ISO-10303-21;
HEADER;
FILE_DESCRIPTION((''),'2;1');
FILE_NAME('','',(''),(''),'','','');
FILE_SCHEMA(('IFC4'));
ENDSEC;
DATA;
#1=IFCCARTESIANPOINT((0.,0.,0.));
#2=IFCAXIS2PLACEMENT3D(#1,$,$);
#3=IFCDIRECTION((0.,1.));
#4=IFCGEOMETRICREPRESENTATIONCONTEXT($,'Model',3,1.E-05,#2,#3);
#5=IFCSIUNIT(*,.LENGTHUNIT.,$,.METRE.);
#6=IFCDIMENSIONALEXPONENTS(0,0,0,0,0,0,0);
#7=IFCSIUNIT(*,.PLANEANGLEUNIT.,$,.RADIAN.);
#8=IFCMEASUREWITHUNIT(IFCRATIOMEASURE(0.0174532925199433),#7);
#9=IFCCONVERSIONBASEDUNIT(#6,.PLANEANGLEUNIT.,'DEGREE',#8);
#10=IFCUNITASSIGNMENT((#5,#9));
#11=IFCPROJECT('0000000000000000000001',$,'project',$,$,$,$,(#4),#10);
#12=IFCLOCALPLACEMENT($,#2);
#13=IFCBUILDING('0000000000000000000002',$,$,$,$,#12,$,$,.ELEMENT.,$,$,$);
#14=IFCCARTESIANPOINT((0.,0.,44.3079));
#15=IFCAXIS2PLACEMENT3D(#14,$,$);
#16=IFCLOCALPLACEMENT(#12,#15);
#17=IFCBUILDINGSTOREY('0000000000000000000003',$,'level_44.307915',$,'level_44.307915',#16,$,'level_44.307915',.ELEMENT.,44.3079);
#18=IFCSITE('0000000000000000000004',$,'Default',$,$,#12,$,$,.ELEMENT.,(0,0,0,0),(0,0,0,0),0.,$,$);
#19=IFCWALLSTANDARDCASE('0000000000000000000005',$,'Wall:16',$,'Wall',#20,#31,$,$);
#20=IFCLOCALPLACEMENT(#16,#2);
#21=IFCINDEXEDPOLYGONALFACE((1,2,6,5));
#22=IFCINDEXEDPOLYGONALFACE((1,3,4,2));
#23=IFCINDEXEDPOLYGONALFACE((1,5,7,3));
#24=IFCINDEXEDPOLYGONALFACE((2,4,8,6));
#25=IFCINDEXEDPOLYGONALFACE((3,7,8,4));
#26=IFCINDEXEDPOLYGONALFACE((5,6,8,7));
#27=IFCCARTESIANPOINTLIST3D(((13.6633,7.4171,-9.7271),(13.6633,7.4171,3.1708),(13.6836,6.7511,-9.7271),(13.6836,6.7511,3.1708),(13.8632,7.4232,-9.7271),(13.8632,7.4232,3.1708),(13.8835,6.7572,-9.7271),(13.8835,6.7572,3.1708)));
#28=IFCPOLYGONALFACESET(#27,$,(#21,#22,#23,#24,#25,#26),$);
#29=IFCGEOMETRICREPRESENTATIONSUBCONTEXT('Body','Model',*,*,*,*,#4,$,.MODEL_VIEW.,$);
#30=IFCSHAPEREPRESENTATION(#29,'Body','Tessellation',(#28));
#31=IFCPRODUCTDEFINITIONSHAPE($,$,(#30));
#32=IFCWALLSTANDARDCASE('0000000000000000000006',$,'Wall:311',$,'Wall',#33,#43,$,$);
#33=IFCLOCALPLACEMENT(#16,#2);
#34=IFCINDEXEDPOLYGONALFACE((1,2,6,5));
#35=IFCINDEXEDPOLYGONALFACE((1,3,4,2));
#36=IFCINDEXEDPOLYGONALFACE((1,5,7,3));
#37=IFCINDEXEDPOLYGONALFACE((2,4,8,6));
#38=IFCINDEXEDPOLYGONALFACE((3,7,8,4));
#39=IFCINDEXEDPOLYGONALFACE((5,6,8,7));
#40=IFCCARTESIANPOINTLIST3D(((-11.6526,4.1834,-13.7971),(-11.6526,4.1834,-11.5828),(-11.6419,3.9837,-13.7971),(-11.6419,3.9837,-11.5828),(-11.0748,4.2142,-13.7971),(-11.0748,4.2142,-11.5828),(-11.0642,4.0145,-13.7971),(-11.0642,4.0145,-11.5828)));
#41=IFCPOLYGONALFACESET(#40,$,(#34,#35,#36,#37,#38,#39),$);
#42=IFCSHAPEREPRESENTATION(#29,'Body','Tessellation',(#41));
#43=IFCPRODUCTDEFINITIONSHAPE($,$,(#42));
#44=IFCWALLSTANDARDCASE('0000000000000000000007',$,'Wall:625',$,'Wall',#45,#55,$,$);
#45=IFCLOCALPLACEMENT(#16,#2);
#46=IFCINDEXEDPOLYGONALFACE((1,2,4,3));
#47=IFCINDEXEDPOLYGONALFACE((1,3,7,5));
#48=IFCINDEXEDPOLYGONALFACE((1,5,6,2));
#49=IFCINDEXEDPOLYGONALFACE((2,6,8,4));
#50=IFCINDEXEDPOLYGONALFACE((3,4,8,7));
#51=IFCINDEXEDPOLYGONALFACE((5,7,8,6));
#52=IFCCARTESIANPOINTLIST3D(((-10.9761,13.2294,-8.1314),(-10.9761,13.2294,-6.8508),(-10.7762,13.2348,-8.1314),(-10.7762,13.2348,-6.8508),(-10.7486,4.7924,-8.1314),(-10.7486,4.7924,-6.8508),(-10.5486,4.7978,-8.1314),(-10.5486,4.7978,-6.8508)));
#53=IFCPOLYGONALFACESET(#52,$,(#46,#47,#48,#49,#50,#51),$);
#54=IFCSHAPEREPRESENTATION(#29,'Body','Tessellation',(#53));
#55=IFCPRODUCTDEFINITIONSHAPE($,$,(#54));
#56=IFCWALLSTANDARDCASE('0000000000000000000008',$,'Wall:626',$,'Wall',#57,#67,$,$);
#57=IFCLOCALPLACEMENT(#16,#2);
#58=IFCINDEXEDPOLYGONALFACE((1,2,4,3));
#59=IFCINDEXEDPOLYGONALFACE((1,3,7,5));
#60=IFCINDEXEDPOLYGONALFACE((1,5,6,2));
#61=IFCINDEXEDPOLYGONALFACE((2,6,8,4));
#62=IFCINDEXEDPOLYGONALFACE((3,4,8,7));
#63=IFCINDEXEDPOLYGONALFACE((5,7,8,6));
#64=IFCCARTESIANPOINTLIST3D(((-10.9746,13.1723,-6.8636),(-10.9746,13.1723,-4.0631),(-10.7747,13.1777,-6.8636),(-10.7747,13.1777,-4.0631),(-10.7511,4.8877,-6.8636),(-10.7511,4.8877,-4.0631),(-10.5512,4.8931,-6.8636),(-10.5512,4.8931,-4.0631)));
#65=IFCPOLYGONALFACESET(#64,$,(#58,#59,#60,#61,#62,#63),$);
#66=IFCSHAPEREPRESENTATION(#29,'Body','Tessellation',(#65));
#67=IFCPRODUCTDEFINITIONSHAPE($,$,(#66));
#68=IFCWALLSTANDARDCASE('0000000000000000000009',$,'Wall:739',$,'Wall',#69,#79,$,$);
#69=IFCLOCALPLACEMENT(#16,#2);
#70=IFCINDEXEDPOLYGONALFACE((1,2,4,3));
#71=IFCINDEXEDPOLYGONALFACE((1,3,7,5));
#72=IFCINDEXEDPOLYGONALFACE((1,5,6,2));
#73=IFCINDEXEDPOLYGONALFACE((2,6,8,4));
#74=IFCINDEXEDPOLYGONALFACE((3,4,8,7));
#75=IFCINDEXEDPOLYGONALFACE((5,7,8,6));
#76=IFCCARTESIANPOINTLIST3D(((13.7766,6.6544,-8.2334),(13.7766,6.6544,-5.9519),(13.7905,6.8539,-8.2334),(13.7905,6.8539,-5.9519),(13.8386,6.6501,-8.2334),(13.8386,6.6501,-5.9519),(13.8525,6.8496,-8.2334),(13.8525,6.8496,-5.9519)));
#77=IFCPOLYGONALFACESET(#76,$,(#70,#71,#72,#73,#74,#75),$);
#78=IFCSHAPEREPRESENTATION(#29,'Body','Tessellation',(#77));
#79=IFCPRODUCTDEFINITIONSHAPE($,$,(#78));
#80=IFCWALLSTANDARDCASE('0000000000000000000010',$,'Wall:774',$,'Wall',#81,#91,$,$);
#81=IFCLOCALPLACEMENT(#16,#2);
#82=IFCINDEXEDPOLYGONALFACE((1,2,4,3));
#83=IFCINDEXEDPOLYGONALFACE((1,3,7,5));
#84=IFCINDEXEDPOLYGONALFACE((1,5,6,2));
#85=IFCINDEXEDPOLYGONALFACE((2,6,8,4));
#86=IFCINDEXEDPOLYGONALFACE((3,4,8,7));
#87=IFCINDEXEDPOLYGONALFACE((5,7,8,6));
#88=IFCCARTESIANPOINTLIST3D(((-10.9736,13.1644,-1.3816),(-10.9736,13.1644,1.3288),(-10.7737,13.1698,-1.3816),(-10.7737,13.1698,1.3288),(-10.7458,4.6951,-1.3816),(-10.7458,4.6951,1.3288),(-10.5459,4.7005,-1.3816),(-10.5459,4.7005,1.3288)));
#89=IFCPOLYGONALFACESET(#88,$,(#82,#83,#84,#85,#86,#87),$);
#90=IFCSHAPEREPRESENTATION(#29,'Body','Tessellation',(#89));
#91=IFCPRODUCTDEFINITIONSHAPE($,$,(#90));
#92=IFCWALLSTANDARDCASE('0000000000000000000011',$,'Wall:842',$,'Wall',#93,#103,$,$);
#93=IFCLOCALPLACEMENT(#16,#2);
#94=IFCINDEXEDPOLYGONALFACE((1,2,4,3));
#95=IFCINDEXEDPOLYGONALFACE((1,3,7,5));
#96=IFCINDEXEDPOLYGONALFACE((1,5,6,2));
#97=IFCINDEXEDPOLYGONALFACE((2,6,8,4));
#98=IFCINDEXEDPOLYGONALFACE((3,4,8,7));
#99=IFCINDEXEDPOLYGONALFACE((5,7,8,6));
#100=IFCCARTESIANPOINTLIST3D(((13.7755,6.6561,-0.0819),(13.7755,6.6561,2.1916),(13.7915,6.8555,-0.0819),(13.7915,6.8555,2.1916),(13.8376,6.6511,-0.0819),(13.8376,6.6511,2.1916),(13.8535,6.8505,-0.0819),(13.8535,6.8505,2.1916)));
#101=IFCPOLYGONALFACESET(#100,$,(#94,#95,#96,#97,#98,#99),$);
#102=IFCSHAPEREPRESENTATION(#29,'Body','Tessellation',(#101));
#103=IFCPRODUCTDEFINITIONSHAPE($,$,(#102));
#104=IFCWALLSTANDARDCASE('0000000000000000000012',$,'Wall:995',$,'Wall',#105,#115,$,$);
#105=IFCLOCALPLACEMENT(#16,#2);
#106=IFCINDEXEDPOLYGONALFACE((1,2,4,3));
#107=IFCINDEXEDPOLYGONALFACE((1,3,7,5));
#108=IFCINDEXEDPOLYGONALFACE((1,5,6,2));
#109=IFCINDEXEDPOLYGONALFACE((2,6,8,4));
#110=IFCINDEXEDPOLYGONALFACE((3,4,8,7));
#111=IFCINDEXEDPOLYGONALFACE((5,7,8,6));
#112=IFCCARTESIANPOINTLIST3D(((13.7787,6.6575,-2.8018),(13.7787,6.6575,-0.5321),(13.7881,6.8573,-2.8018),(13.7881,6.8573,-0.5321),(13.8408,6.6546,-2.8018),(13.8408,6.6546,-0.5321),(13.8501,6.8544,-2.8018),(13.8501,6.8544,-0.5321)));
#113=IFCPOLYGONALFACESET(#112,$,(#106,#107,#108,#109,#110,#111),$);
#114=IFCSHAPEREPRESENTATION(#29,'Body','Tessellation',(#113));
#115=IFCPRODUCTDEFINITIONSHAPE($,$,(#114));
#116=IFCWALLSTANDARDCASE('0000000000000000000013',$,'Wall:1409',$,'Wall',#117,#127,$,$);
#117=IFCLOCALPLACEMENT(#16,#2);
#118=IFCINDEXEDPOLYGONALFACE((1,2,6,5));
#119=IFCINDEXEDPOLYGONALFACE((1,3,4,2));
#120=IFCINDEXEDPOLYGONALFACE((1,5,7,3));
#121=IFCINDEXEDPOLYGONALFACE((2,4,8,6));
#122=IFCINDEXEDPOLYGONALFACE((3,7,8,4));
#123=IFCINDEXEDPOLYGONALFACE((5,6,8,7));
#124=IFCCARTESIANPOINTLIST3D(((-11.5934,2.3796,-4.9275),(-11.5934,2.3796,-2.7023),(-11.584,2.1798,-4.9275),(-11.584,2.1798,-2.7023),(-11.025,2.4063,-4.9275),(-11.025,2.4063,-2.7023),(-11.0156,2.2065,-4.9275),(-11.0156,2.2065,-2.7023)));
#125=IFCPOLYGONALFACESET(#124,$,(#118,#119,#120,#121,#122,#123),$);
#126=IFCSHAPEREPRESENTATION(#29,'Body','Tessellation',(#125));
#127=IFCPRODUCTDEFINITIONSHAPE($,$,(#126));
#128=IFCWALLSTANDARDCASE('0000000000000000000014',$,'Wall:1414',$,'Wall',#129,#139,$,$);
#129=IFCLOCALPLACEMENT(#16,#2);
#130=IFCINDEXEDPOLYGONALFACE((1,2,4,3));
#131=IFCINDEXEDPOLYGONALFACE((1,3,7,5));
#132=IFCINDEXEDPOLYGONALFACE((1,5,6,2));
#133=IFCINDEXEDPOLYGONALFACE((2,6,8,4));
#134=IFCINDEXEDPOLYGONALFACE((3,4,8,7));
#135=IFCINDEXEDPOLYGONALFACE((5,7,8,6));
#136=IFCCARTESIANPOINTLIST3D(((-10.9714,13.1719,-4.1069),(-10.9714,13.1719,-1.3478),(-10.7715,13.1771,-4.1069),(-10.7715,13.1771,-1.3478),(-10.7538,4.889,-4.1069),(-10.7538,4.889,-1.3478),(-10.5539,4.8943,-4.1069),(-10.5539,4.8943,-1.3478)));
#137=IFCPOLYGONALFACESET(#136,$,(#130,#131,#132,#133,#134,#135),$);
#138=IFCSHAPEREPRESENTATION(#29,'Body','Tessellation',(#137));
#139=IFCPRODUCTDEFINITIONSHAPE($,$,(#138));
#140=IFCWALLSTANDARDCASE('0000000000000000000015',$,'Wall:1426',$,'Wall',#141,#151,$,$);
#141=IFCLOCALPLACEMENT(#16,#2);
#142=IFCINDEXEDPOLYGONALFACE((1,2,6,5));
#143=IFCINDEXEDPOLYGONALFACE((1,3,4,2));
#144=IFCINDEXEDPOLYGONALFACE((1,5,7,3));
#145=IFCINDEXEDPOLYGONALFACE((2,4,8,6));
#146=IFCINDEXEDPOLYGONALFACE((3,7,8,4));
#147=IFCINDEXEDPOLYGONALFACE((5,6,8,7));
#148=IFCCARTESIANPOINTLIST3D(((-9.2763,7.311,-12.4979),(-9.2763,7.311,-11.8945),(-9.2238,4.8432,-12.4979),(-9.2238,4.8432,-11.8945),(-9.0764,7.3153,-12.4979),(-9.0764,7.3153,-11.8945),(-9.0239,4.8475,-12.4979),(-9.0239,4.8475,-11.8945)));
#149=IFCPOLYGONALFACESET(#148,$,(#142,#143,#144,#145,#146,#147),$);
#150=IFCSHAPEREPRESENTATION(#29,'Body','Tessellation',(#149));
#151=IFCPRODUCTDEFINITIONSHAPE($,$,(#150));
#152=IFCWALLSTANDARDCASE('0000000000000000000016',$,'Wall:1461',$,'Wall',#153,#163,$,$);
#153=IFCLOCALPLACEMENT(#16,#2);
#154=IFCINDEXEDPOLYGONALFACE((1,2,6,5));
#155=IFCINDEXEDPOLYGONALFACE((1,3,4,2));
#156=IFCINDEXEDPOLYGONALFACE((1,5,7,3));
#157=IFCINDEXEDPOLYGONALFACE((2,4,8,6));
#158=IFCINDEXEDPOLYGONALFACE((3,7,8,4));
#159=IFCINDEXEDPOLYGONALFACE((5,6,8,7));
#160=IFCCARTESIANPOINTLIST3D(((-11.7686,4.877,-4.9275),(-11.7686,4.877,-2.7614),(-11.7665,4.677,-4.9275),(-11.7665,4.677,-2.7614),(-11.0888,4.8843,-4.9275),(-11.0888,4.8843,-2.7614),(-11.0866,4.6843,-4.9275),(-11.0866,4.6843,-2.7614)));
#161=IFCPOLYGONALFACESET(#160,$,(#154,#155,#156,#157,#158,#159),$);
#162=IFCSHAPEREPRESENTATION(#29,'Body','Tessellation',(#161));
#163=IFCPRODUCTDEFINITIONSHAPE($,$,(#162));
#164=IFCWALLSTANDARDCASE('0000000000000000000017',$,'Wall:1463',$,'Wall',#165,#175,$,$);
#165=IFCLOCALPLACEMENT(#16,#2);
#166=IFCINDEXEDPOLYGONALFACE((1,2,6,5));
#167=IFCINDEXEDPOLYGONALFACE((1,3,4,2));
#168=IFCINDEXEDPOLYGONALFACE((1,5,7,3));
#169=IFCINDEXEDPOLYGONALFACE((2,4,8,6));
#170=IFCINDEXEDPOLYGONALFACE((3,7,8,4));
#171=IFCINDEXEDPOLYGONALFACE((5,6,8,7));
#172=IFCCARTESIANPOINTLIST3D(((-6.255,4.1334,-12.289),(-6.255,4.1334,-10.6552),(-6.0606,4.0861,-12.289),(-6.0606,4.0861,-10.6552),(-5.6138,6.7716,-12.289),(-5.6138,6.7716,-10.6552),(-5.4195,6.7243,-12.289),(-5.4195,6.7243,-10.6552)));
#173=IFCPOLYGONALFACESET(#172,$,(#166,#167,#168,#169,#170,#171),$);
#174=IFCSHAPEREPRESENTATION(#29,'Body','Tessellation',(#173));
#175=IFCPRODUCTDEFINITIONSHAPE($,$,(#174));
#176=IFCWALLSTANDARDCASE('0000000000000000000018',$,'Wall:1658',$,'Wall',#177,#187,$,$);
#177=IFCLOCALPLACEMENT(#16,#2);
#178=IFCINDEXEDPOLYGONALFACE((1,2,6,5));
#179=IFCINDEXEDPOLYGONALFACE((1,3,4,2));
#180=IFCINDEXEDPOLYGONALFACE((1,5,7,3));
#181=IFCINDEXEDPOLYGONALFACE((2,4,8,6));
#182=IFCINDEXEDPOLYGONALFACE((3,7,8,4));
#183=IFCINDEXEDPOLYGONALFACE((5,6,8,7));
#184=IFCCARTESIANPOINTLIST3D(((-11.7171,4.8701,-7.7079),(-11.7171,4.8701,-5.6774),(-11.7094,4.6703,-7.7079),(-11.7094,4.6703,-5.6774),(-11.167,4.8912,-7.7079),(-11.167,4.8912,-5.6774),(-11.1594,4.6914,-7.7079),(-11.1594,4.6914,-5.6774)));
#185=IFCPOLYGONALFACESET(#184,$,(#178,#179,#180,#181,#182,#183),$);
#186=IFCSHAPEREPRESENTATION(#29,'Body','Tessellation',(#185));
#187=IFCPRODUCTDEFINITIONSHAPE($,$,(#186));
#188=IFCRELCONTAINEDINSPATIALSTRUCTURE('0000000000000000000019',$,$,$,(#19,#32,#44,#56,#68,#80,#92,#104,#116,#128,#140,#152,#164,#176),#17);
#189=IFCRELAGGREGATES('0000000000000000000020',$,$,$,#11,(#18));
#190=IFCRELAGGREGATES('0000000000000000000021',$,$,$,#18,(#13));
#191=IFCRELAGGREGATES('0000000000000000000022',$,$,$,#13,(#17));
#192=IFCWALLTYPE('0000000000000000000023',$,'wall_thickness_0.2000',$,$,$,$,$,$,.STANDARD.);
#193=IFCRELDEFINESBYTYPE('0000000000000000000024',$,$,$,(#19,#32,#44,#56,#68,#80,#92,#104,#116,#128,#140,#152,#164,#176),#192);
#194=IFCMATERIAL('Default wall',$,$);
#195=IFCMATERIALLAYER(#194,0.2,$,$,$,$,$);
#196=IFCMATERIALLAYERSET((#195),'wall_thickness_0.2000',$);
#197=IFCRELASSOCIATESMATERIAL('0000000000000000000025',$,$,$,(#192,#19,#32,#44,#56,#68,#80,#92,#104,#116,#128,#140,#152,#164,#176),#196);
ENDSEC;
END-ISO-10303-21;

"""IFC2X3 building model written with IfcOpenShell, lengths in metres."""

from ifc_helpers import new_model, entity, si_unit, converted_unit, direction, frame, origin, place, context, subcontext, project, spatial, polyline, outline, extrude, material, layer, layer_set, layer_usage, type_object, element, save


model = new_model("IFC2X3")

# Units and contexts
model_context = context("Model", 3, precision=1e-05, world=origin(), true_north=direction((0.0, 1.0)))
body_context = subcontext(model_context, "Body", "Model", "MODEL_VIEW")
ifc_project = project(units=[si_unit("LENGTHUNIT", "METRE"), converted_unit("PLANEANGLEUNIT", "DEGREE", entity("IfcRatioMeasure", 0.0174532925199433), si_unit("PLANEANGLEUNIT", "RADIAN"), dimensions=[0, 0, 0, 0, 0, 0, 0])], contexts=[model_context])

# Site, building, storey
placement_1 = place(None, origin())
site = spatial("IfcSite", under=ifc_project, at=placement_1, Name="Default", CompositionType="ELEMENT", RefLatitude=(0, 0, 0, 0), RefLongitude=(0, 0, 0, 0), RefElevation=0.0)
building = spatial("IfcBuilding", under=site, at=placement_1, CompositionType="ELEMENT")
storey_placement = place(placement_1, frame((0.0, 0.0, 44.3079)))
storey = spatial("IfcBuildingStorey", under=building, at=storey_placement, Name="level_44.307915", ObjectType="level_44.307915", LongName="level_44.307915", CompositionType="ELEMENT", Elevation=44.3079)

# Walls
ifc_material = material(Name="Default wall")
ifc_layer = layer(ifc_material, 0.2)
ifc_layer_set = layer_set([ifc_layer], Name="wall_thickness_0.2000")
ifc_layer_usage = layer_usage(ifc_layer_set, "AXIS2", "POSITIVE", -0.1)
wall_type = type_object("IfcWallType", Name="wall_thickness_0.2000", PredefinedType="STANDARD", material=ifc_layer_set)
placement_2 = place(placement_1, frame((0.0, 0.0, 34.5808)))
wall_1_placement = place(placement_2, frame((13.7835, 6.7542, 0.0), z_axis=(0.0, 0.0, 1.0), x_axis=(-0.03042, 0.999537, 0.0)))
element("IfcWallStandardCase", 1, at=wall_1_placement, inside=storey, type_object=wall_type, material=ifc_layer_usage, Name="Wall:16", ObjectType="Wall", context=body_context, shape_type="SweptSolid", body=[
    extrude(outline(polyline([(0.6663, -0.1), (0.6663, 0.1), (0.0, 0.1), (0.0, -0.1), (0.6663, -0.1)])), origin(), (0.0, 0.0, 1.0), 12.8979),
])
placement_3 = place(placement_1, frame((0.0, 0.0, 30.5108)))
wall_2_placement = place(placement_3, frame((-11.0695, 4.1143, 0.0), z_axis=(0.0, 0.0, 1.0), x_axis=(-0.998585, -0.053174, 0.0)))
element("IfcWallStandardCase", 2, at=wall_2_placement, inside=storey, type_object=wall_type, material=ifc_layer_usage, Name="Wall:311", ObjectType="Wall", context=body_context, shape_type="SweptSolid", body=[
    extrude(outline(polyline([(0.5786, -0.1), (0.5786, 0.1), (0.0, 0.1), (0.0, -0.1), (0.5786, -0.1)])), origin(), (0.0, 0.0, 1.0), 2.2143),
])
placement_4 = place(placement_1, frame((0.0, 0.0, 36.1765)))
wall_3_placement = place(placement_4, frame((-10.6486, 4.7951, 0.0), z_axis=(0.0, 0.0, 1.0), x_axis=(-0.026962, 0.999636, 0.0)))
element("IfcWallStandardCase", 3, at=wall_3_placement, inside=storey, type_object=wall_type, material=ifc_layer_usage, Name="Wall:625", ObjectType="Wall", context=body_context, shape_type="SweptSolid", body=[
    extrude(outline(polyline([(8.44, -0.1), (8.44, 0.1), (0.0, 0.1), (0.0, -0.1), (8.44, -0.1)])), origin(), (0.0, 0.0, 1.0), 1.2806),
])
placement_5 = place(placement_1, frame((0.0, 0.0, 37.4443)))
wall_4_placement = place(placement_5, frame((-10.6512, 4.8904, 0.0), z_axis=(0.0, 0.0, 1.0), x_axis=(-0.026962, 0.999636, 0.0)))
element("IfcWallStandardCase", 4, at=wall_4_placement, inside=storey, type_object=wall_type, material=ifc_layer_usage, Name="Wall:626", ObjectType="Wall", context=body_context, shape_type="SweptSolid", body=[
    extrude(outline(polyline([(8.2876, -0.1), (8.2876, 0.1), (0.0, 0.1), (0.0, -0.1), (8.2876, -0.1)])), origin(), (0.0, 0.0, 1.0), 2.8005),
])
placement_6 = place(placement_1, frame((0.0, 0.0, 36.0745)))
wall_5_placement = place(placement_6, frame((13.8456, 6.7498, 0.0), z_axis=(0.0, 0.0, 1.0), x_axis=(-0.997581, 0.069509, 0.0)))
element("IfcWallStandardCase", 5, at=wall_5_placement, inside=storey, type_object=wall_type, material=ifc_layer_usage, Name="Wall:739", ObjectType="Wall", context=body_context, shape_type="SweptSolid", body=[
    extrude(outline(polyline([(0.0622, -0.1), (0.0622, 0.1), (0.0, 0.1), (0.0, -0.1), (0.0622, -0.1)])), origin(), (0.0, 0.0, 1.0), 2.2815),
])
placement_7 = place(placement_1, frame((0.0, 0.0, 42.9263)))
wall_6_placement = place(placement_7, frame((-10.6458, 4.6978, 0.0), z_axis=(0.0, 0.0, 1.0), x_axis=(-0.026888, 0.999638, 0.0)))
element("IfcWallStandardCase", 6, at=wall_6_placement, inside=storey, type_object=wall_type, material=ifc_layer_usage, Name="Wall:774", ObjectType="Wall", context=body_context, shape_type="SweptSolid", body=[
    extrude(outline(polyline([(8.4724, -0.1), (8.4724, 0.1), (0.0, 0.1), (0.0, -0.1), (8.4724, -0.1)])), origin(), (0.0, 0.0, 1.0), 2.7104),
])
placement_8 = place(placement_1, frame((0.0, 0.0, 44.226)))
wall_7_placement = place(placement_8, frame((13.8456, 6.7508, 0.0), z_axis=(0.0, 0.0, 1.0), x_axis=(-0.996799, 0.079944, 0.0)))
element("IfcWallStandardCase", 7, at=wall_7_placement, inside=storey, type_object=wall_type, material=ifc_layer_usage, Name="Wall:842", ObjectType="Wall", context=body_context, shape_type="SweptSolid", body=[
    extrude(outline(polyline([(0.0623, -0.1), (0.0623, 0.1), (0.0, 0.1), (0.0, -0.1), (0.0623, -0.1)])), origin(), (0.0, 0.0, 1.0), 2.2735),
])
placement_9 = place(placement_1, frame((0.0, 0.0, 41.5061)))
wall_8_placement = place(placement_9, frame((13.8455, 6.7545, 0.0), z_axis=(0.0, 0.0, 1.0), x_axis=(-0.998908, 0.04671, 0.0)))
element("IfcWallStandardCase", 8, at=wall_8_placement, inside=storey, type_object=wall_type, material=ifc_layer_usage, Name="Wall:995", ObjectType="Wall", context=body_context, shape_type="SweptSolid", body=[
    extrude(outline(polyline([(0.0621, -0.1), (0.0621, 0.1), (0.0, 0.1), (0.0, -0.1), (0.0621, -0.1)])), origin(), (0.0, 0.0, 1.0), 2.2697),
])
placement_10 = place(placement_1, frame((0.0, 0.0, 39.3804)))
wall_9_placement = place(placement_10, frame((-11.0203, 2.3064, 0.0), z_axis=(0.0, 0.0, 1.0), x_axis=(-0.998901, -0.046874, 0.0)))
element("IfcWallStandardCase", 9, at=wall_9_placement, inside=storey, type_object=wall_type, material=ifc_layer_usage, Name="Wall:1409", ObjectType="Wall", context=body_context, shape_type="SweptSolid", body=[
    extrude(outline(polyline([(0.569, -0.1), (0.569, 0.1), (0.0, 0.1), (0.0, -0.1), (0.569, -0.1)])), origin(), (0.0, 0.0, 1.0), 2.2253),
])
placement_11 = place(placement_1, frame((0.0, 0.0, 40.201)))
wall_10_placement = place(placement_11, frame((-10.6538, 4.8916, 0.0), z_axis=(0.0, 0.0, 1.0), x_axis=(-0.026266, 0.999655, 0.0)))
element("IfcWallStandardCase", 10, at=wall_10_placement, inside=storey, type_object=wall_type, material=ifc_layer_usage, Name="Wall:1414", ObjectType="Wall", context=body_context, shape_type="SweptSolid", body=[
    extrude(outline(polyline([(8.2857, -0.1), (8.2857, 0.1), (0.0, 0.1), (0.0, -0.1), (8.2857, -0.1)])), origin(), (0.0, 0.0, 1.0), 2.7591),
])
placement_12 = place(placement_1, frame((0.0, 0.0, 31.81)))
wall_11_placement = place(placement_12, frame((-9.1238, 4.8453, 0.0), z_axis=(0.0, 0.0, 1.0), x_axis=(-0.021266, 0.999774, 0.0)))
element("IfcWallStandardCase", 11, at=wall_11_placement, inside=storey, type_object=wall_type, material=ifc_layer_usage, Name="Wall:1426", ObjectType="Wall", context=body_context, shape_type="SweptSolid", body=[
    extrude(outline(polyline([(2.4684, -0.1), (2.4684, 0.1), (0.0, 0.1), (0.0, -0.1), (2.4684, -0.1)])), origin(), (0.0, 0.0, 1.0), 0.6034),
])
placement_13 = place(placement_1, frame((0.0, 0.0, 39.3804)))
wall_12_placement = place(placement_13, frame((-11.0877, 4.7843, 0.0), z_axis=(0.0, 0.0, 1.0), x_axis=(-0.999942, -0.010813, 0.0)))
element("IfcWallStandardCase", 12, at=wall_12_placement, inside=storey, type_object=wall_type, material=ifc_layer_usage, Name="Wall:1461", ObjectType="Wall", context=body_context, shape_type="SweptSolid", body=[
    extrude(outline(polyline([(0.6799, -0.1), (0.6799, 0.1), (0.0, 0.1), (0.0, -0.1), (0.6799, -0.1)])), origin(), (0.0, 0.0, 1.0), 2.1661),
])
placement_14 = place(placement_1, frame((0.0, 0.0, 32.0189)))
wall_13_placement = place(placement_14, frame((-5.5166, 6.748, 0.0), z_axis=(0.0, 0.0, 1.0), x_axis=(-0.236158, -0.971715, 0.0)))
element("IfcWallStandardCase", 13, at=wall_13_placement, inside=storey, type_object=wall_type, material=ifc_layer_usage, Name="Wall:1463", ObjectType="Wall", context=body_context, shape_type="SweptSolid", body=[
    extrude(outline(polyline([(2.715, -0.1), (2.715, 0.1), (0.0, 0.1), (0.0, -0.1), (2.715, -0.1)])), origin(), (0.0, 0.0, 1.0), 1.6338),
])
placement_15 = place(placement_1, frame((0.0, 0.0, 36.6)))
wall_14_placement = place(placement_15, frame((-11.1632, 4.7913, 0.0), z_axis=(0.0, 0.0, 1.0), x_axis=(-0.999263, -0.038381, 0.0)))
element("IfcWallStandardCase", 14, at=wall_14_placement, inside=storey, type_object=wall_type, material=ifc_layer_usage, Name="Wall:1658", ObjectType="Wall", context=body_context, shape_type="SweptSolid", body=[
    extrude(outline(polyline([(0.5505, -0.1), (0.5505, 0.1), (0.0, 0.1), (0.0, -0.1), (0.5505, -0.1)])), origin(), (0.0, 0.0, 1.0), 2.0305),
])

save(model, "model.ifc")
